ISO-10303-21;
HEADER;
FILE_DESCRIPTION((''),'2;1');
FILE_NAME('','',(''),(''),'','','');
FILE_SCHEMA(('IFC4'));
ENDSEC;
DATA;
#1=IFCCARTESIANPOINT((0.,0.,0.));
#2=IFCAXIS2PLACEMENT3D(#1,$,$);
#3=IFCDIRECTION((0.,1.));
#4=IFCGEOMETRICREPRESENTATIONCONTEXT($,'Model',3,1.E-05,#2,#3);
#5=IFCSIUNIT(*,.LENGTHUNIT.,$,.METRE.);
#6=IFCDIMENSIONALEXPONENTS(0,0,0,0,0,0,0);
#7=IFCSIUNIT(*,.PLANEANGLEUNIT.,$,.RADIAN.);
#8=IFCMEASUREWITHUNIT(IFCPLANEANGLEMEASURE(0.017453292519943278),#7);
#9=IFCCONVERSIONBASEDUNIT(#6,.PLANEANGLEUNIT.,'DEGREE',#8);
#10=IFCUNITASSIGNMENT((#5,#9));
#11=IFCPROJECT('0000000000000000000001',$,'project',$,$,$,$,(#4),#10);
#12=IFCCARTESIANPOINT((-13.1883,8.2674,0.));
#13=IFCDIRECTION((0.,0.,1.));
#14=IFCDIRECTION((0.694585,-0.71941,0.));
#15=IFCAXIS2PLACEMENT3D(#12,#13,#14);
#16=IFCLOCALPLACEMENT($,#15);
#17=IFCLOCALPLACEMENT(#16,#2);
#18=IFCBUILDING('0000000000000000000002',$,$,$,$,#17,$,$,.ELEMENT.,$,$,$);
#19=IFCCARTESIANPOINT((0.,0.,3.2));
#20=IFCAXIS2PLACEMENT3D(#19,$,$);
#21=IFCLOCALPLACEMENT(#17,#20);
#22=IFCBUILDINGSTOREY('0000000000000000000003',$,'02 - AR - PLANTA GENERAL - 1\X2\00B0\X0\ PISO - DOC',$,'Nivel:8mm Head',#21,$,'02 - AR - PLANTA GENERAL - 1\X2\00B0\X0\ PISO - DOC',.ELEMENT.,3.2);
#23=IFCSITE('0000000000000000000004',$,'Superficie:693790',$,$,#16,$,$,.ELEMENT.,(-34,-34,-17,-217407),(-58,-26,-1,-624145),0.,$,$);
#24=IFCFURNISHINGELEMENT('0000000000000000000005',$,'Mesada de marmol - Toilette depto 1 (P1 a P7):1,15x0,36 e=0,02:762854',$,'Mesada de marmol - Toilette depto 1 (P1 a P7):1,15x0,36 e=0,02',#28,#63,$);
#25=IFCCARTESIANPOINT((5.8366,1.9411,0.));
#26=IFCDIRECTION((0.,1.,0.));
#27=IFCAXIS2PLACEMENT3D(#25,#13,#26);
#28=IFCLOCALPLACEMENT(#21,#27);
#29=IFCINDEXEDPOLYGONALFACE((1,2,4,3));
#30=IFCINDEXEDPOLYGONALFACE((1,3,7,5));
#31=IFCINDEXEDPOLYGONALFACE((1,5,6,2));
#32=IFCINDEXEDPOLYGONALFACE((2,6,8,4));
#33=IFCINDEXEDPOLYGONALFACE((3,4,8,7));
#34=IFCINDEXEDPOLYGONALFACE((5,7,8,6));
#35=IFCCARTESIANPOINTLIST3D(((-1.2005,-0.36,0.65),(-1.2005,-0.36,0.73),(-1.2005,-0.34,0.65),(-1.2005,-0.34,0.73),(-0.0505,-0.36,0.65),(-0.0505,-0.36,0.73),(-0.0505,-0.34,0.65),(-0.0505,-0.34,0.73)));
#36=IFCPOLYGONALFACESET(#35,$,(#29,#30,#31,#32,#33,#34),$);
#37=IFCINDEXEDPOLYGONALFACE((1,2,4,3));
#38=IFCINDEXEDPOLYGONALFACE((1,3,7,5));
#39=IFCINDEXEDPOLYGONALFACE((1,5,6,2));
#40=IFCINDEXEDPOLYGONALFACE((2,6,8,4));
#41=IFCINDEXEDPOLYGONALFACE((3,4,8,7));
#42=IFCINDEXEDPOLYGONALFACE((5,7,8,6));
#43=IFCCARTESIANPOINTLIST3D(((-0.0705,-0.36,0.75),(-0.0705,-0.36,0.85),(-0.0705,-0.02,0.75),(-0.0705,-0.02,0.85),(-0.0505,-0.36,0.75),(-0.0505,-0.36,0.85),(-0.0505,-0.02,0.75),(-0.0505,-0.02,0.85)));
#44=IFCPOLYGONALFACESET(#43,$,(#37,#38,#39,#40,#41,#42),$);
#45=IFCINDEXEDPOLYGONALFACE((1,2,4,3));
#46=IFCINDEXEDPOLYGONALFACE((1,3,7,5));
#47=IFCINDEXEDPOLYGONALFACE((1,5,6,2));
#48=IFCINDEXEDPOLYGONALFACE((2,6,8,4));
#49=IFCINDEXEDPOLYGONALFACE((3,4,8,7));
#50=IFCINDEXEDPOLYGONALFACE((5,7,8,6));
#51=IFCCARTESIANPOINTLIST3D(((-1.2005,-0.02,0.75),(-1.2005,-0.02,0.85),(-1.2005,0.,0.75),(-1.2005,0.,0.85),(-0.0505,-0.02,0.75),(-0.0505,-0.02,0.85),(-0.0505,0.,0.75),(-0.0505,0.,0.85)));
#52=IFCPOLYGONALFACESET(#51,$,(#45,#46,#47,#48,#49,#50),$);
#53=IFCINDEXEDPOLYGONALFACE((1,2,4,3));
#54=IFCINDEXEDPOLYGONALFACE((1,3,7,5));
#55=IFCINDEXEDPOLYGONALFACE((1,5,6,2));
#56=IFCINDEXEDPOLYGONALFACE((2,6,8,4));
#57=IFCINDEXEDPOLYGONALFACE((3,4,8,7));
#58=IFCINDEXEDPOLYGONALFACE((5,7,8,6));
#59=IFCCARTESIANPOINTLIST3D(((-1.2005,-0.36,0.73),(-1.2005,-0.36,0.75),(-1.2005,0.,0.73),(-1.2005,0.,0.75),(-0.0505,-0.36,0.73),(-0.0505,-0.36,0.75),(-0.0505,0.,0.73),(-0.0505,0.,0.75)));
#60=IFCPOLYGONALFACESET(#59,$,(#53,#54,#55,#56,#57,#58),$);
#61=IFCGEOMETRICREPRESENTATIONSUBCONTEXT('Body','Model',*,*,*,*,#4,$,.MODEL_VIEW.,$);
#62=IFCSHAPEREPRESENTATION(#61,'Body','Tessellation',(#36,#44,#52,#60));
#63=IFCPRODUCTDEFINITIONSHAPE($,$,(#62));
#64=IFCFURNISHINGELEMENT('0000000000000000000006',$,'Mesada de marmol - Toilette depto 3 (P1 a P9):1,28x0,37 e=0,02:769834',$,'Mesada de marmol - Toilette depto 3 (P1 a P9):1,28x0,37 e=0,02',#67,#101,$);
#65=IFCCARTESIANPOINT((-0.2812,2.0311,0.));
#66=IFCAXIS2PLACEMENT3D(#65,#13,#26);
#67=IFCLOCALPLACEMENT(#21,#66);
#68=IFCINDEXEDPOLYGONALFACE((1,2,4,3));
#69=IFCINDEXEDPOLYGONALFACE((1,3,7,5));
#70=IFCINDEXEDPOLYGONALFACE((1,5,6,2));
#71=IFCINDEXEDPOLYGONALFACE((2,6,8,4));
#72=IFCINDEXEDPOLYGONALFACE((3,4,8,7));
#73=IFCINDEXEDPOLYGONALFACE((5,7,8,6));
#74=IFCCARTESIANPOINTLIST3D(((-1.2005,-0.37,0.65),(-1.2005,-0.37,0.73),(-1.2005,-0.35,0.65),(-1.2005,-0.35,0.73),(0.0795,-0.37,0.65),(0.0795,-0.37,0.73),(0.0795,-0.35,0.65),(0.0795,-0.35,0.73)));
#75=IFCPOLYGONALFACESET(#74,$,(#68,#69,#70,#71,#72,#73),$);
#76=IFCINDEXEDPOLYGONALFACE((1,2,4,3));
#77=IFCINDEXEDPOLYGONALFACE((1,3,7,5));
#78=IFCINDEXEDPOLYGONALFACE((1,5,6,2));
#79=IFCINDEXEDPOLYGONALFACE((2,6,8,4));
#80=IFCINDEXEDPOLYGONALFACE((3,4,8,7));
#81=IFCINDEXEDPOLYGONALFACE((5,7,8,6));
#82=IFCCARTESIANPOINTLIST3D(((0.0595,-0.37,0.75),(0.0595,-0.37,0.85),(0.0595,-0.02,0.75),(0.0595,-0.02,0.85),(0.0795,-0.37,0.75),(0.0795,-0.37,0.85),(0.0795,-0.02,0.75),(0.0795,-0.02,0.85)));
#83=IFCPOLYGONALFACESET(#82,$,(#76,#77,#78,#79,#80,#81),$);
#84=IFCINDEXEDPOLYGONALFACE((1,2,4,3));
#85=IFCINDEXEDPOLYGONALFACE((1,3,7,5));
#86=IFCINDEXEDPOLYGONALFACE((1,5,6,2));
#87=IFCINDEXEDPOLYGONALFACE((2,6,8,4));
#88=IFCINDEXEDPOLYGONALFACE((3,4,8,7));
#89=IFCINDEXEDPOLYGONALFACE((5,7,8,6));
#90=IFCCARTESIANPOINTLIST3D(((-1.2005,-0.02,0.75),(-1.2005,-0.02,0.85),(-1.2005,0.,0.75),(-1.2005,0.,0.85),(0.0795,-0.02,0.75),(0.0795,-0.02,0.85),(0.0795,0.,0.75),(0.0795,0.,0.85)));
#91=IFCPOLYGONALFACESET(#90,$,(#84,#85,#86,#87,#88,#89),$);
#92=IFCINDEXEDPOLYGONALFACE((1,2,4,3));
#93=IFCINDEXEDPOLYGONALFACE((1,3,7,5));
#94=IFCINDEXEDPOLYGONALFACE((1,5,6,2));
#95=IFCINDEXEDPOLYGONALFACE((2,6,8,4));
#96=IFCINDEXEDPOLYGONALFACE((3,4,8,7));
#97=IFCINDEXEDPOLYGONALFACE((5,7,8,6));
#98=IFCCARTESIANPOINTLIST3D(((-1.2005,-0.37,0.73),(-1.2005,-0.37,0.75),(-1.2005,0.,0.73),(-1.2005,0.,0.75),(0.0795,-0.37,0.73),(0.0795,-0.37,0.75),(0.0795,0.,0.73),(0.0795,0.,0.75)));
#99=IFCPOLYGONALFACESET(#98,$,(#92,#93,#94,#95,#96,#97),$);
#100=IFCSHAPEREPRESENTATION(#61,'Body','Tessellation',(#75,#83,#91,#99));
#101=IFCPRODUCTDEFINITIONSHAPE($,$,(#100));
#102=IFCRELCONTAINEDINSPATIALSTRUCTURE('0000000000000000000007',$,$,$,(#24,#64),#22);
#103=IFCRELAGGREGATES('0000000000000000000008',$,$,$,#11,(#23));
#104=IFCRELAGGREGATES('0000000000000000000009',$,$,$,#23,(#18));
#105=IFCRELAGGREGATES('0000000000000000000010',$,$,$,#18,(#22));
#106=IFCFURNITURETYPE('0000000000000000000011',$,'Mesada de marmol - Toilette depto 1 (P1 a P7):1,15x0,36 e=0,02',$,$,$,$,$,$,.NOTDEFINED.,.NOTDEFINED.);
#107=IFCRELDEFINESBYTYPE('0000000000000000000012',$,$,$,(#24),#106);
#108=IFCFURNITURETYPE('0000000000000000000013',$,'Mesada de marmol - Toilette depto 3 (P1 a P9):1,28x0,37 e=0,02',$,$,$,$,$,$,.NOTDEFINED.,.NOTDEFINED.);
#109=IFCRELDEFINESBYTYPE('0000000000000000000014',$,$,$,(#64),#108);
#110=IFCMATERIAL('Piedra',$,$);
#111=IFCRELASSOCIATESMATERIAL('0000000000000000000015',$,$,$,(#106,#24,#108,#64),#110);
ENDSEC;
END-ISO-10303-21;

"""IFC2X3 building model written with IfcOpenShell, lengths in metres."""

from ifc_helpers import new_model, entity, si_unit, converted_unit, direction, frame, frame_2d, origin, origin_2d_with_axis, place, context, subcontext, project, spatial, rectangle, extrude, source, transform, mapped, material, type_object, type_shapes, element, save


model = new_model("IFC2X3")

# Units and contexts
model_context = context("Model", 3, precision=1e-05, world=origin(), true_north=direction((0.0, 1.0)))
body_context = subcontext(model_context, "Body", "Model", "MODEL_VIEW")
ifc_project = project(units=[si_unit("LENGTHUNIT", "METRE"), converted_unit("PLANEANGLEUNIT", "DEGREE", entity("IfcPlaneAngleMeasure", 0.017453292519943278), si_unit("PLANEANGLEUNIT", "RADIAN"), dimensions=[0, 0, 0, 0, 0, 0, 0])], contexts=[model_context])

# Site, building, storey
site_placement = place(None, frame((-13.1883, 8.2674, 0.0), z_axis=(0.0, 0.0, 1.0), x_axis=(0.694585, -0.71941, 0.0)))
site = spatial("IfcSite", under=ifc_project, at=site_placement, Name="Superficie:693790", CompositionType="ELEMENT", RefLatitude=(-34, -34, -17, -217407), RefLongitude=(-58, -26, -1, -624145), RefElevation=0.0)
building_placement = place(site_placement, origin())
building = spatial("IfcBuilding", under=site, at=building_placement, CompositionType="ELEMENT")
storey_placement = place(building_placement, frame((0.0, 0.0, 3.2)))
storey = spatial("IfcBuildingStorey", under=building, at=storey_placement, Name="02 - AR - PLANTA GENERAL - 1° PISO - DOC", ObjectType="Nivel:8mm Head", LongName="02 - AR - PLANTA GENERAL - 1° PISO - DOC", CompositionType="ELEMENT", Elevation=3.2)

# Furnishing elements
ifc_material_1 = material(Name="Piedra")
furniture_type_1 = type_object("IfcFurnitureType", Name="Mesada de marmol - Toilette depto 1 (P1 a P7):1,15x0,36 e=0,02", AssemblyPlace="NOTDEFINED", material=ifc_material_1)
shared_shape_1 = source(origin(), body_context, "Body", "SweptSolid", [
    extrude(rectangle(XDim=0.02, YDim=1.15, at=frame_2d((0.0, 0.0), x_axis=(1.0, 0.0))), frame((-0.6255, -0.35, 0.65), z_axis=(0.0, 0.0, 1.0), x_axis=(0.0, 1.0, 0.0)), (0.0, 0.0, 1.0), 0.08),
    extrude(rectangle(XDim=0.02, YDim=0.34, at=origin_2d_with_axis()), frame((-0.0605, -0.19, 0.75), z_axis=(0.0, 0.0, 1.0), x_axis=(-1.0, 0.0, 0.0)), (0.0, 0.0, 1.0), 0.1),
    extrude(rectangle(XDim=0.02, YDim=1.15, at=frame_2d((0.0, 0.0), x_axis=(1.0, 0.0))), frame((-0.6255, -0.01, 0.75), z_axis=(0.0, 0.0, 1.0), x_axis=(0.0, -1.0, 0.0)), (0.0, 0.0, 1.0), 0.1),
    extrude(rectangle(XDim=1.15, YDim=0.36, at=frame_2d((0.0, 0.0), x_axis=(1.0, 0.0))), frame((-0.6255, -0.18, 0.73), z_axis=(0.0, 0.0, 1.0), x_axis=(-1.0, 0.0, 0.0)), (0.0, 0.0, 1.0), 0.02),
])
type_shapes(furniture_type_1, [shared_shape_1])
furnishing_1_placement = place(storey_placement, frame((5.8366, 1.9411, 0.0), z_axis=(0.0, 0.0, 1.0), x_axis=(0.0, 1.0, 0.0)))
element("IfcFurnishingElement", 1, at=furnishing_1_placement, inside=storey, type_object=furniture_type_1, material=ifc_material_1, Name="Mesada de marmol - Toilette depto 1 (P1 a P7):1,15x0,36 e=0,02:762854", ObjectType="Mesada de marmol - Toilette depto 1 (P1 a P7):1,15x0,36 e=0,02", context=body_context, shape_type="MappedRepresentation", body=[
    mapped(shared_shape_1, transform((0.0, 0.0, 0.0), scale=1.0)),
])
furniture_type_2 = type_object("IfcFurnitureType", Name="Mesada de marmol - Toilette depto 3 (P1 a P9):1,28x0,37 e=0,02", AssemblyPlace="NOTDEFINED", material=ifc_material_1)
shared_shape_2 = source(origin(), body_context, "Body", "SweptSolid", [
    extrude(rectangle(XDim=0.02, YDim=1.28, at=origin_2d_with_axis()), frame((-0.5605, -0.36, 0.65), z_axis=(0.0, 0.0, 1.0), x_axis=(0.0, 1.0, 0.0)), (0.0, 0.0, 1.0), 0.08),
    extrude(rectangle(XDim=0.02, YDim=0.35, at=frame_2d((0.0, 0.0), x_axis=(1.0, 0.0))), frame((0.0695, -0.195, 0.75), z_axis=(0.0, 0.0, 1.0), x_axis=(-1.0, 0.0, 0.0)), (0.0, 0.0, 1.0), 0.1),
    extrude(rectangle(XDim=0.02, YDim=1.28, at=origin_2d_with_axis()), frame((-0.5605, -0.01, 0.75), z_axis=(0.0, 0.0, 1.0), x_axis=(0.0, -1.0, 0.0)), (0.0, 0.0, 1.0), 0.1),
    extrude(rectangle(XDim=1.28, YDim=0.37, at=frame_2d((0.0, 0.0), x_axis=(1.0, 0.0))), frame((-0.5605, -0.185, 0.73), z_axis=(0.0, 0.0, 1.0), x_axis=(-1.0, 0.0, 0.0)), (0.0, 0.0, 1.0), 0.02),
])
type_shapes(furniture_type_2, [shared_shape_2])
furnishing_2_placement = place(storey_placement, frame((-0.2812, 2.0311, 0.0), z_axis=(0.0, 0.0, 1.0), x_axis=(0.0, 1.0, 0.0)))
element("IfcFurnishingElement", 2, at=furnishing_2_placement, inside=storey, type_object=furniture_type_2, material=ifc_material_1, Name="Mesada de marmol - Toilette depto 3 (P1 a P9):1,28x0,37 e=0,02:769834", ObjectType="Mesada de marmol - Toilette depto 3 (P1 a P9):1,28x0,37 e=0,02", context=body_context, shape_type="MappedRepresentation", body=[
    mapped(shared_shape_2, transform((0.0, 0.0, 0.0), scale=1.0)),
])

save(model, "model.ifc")
